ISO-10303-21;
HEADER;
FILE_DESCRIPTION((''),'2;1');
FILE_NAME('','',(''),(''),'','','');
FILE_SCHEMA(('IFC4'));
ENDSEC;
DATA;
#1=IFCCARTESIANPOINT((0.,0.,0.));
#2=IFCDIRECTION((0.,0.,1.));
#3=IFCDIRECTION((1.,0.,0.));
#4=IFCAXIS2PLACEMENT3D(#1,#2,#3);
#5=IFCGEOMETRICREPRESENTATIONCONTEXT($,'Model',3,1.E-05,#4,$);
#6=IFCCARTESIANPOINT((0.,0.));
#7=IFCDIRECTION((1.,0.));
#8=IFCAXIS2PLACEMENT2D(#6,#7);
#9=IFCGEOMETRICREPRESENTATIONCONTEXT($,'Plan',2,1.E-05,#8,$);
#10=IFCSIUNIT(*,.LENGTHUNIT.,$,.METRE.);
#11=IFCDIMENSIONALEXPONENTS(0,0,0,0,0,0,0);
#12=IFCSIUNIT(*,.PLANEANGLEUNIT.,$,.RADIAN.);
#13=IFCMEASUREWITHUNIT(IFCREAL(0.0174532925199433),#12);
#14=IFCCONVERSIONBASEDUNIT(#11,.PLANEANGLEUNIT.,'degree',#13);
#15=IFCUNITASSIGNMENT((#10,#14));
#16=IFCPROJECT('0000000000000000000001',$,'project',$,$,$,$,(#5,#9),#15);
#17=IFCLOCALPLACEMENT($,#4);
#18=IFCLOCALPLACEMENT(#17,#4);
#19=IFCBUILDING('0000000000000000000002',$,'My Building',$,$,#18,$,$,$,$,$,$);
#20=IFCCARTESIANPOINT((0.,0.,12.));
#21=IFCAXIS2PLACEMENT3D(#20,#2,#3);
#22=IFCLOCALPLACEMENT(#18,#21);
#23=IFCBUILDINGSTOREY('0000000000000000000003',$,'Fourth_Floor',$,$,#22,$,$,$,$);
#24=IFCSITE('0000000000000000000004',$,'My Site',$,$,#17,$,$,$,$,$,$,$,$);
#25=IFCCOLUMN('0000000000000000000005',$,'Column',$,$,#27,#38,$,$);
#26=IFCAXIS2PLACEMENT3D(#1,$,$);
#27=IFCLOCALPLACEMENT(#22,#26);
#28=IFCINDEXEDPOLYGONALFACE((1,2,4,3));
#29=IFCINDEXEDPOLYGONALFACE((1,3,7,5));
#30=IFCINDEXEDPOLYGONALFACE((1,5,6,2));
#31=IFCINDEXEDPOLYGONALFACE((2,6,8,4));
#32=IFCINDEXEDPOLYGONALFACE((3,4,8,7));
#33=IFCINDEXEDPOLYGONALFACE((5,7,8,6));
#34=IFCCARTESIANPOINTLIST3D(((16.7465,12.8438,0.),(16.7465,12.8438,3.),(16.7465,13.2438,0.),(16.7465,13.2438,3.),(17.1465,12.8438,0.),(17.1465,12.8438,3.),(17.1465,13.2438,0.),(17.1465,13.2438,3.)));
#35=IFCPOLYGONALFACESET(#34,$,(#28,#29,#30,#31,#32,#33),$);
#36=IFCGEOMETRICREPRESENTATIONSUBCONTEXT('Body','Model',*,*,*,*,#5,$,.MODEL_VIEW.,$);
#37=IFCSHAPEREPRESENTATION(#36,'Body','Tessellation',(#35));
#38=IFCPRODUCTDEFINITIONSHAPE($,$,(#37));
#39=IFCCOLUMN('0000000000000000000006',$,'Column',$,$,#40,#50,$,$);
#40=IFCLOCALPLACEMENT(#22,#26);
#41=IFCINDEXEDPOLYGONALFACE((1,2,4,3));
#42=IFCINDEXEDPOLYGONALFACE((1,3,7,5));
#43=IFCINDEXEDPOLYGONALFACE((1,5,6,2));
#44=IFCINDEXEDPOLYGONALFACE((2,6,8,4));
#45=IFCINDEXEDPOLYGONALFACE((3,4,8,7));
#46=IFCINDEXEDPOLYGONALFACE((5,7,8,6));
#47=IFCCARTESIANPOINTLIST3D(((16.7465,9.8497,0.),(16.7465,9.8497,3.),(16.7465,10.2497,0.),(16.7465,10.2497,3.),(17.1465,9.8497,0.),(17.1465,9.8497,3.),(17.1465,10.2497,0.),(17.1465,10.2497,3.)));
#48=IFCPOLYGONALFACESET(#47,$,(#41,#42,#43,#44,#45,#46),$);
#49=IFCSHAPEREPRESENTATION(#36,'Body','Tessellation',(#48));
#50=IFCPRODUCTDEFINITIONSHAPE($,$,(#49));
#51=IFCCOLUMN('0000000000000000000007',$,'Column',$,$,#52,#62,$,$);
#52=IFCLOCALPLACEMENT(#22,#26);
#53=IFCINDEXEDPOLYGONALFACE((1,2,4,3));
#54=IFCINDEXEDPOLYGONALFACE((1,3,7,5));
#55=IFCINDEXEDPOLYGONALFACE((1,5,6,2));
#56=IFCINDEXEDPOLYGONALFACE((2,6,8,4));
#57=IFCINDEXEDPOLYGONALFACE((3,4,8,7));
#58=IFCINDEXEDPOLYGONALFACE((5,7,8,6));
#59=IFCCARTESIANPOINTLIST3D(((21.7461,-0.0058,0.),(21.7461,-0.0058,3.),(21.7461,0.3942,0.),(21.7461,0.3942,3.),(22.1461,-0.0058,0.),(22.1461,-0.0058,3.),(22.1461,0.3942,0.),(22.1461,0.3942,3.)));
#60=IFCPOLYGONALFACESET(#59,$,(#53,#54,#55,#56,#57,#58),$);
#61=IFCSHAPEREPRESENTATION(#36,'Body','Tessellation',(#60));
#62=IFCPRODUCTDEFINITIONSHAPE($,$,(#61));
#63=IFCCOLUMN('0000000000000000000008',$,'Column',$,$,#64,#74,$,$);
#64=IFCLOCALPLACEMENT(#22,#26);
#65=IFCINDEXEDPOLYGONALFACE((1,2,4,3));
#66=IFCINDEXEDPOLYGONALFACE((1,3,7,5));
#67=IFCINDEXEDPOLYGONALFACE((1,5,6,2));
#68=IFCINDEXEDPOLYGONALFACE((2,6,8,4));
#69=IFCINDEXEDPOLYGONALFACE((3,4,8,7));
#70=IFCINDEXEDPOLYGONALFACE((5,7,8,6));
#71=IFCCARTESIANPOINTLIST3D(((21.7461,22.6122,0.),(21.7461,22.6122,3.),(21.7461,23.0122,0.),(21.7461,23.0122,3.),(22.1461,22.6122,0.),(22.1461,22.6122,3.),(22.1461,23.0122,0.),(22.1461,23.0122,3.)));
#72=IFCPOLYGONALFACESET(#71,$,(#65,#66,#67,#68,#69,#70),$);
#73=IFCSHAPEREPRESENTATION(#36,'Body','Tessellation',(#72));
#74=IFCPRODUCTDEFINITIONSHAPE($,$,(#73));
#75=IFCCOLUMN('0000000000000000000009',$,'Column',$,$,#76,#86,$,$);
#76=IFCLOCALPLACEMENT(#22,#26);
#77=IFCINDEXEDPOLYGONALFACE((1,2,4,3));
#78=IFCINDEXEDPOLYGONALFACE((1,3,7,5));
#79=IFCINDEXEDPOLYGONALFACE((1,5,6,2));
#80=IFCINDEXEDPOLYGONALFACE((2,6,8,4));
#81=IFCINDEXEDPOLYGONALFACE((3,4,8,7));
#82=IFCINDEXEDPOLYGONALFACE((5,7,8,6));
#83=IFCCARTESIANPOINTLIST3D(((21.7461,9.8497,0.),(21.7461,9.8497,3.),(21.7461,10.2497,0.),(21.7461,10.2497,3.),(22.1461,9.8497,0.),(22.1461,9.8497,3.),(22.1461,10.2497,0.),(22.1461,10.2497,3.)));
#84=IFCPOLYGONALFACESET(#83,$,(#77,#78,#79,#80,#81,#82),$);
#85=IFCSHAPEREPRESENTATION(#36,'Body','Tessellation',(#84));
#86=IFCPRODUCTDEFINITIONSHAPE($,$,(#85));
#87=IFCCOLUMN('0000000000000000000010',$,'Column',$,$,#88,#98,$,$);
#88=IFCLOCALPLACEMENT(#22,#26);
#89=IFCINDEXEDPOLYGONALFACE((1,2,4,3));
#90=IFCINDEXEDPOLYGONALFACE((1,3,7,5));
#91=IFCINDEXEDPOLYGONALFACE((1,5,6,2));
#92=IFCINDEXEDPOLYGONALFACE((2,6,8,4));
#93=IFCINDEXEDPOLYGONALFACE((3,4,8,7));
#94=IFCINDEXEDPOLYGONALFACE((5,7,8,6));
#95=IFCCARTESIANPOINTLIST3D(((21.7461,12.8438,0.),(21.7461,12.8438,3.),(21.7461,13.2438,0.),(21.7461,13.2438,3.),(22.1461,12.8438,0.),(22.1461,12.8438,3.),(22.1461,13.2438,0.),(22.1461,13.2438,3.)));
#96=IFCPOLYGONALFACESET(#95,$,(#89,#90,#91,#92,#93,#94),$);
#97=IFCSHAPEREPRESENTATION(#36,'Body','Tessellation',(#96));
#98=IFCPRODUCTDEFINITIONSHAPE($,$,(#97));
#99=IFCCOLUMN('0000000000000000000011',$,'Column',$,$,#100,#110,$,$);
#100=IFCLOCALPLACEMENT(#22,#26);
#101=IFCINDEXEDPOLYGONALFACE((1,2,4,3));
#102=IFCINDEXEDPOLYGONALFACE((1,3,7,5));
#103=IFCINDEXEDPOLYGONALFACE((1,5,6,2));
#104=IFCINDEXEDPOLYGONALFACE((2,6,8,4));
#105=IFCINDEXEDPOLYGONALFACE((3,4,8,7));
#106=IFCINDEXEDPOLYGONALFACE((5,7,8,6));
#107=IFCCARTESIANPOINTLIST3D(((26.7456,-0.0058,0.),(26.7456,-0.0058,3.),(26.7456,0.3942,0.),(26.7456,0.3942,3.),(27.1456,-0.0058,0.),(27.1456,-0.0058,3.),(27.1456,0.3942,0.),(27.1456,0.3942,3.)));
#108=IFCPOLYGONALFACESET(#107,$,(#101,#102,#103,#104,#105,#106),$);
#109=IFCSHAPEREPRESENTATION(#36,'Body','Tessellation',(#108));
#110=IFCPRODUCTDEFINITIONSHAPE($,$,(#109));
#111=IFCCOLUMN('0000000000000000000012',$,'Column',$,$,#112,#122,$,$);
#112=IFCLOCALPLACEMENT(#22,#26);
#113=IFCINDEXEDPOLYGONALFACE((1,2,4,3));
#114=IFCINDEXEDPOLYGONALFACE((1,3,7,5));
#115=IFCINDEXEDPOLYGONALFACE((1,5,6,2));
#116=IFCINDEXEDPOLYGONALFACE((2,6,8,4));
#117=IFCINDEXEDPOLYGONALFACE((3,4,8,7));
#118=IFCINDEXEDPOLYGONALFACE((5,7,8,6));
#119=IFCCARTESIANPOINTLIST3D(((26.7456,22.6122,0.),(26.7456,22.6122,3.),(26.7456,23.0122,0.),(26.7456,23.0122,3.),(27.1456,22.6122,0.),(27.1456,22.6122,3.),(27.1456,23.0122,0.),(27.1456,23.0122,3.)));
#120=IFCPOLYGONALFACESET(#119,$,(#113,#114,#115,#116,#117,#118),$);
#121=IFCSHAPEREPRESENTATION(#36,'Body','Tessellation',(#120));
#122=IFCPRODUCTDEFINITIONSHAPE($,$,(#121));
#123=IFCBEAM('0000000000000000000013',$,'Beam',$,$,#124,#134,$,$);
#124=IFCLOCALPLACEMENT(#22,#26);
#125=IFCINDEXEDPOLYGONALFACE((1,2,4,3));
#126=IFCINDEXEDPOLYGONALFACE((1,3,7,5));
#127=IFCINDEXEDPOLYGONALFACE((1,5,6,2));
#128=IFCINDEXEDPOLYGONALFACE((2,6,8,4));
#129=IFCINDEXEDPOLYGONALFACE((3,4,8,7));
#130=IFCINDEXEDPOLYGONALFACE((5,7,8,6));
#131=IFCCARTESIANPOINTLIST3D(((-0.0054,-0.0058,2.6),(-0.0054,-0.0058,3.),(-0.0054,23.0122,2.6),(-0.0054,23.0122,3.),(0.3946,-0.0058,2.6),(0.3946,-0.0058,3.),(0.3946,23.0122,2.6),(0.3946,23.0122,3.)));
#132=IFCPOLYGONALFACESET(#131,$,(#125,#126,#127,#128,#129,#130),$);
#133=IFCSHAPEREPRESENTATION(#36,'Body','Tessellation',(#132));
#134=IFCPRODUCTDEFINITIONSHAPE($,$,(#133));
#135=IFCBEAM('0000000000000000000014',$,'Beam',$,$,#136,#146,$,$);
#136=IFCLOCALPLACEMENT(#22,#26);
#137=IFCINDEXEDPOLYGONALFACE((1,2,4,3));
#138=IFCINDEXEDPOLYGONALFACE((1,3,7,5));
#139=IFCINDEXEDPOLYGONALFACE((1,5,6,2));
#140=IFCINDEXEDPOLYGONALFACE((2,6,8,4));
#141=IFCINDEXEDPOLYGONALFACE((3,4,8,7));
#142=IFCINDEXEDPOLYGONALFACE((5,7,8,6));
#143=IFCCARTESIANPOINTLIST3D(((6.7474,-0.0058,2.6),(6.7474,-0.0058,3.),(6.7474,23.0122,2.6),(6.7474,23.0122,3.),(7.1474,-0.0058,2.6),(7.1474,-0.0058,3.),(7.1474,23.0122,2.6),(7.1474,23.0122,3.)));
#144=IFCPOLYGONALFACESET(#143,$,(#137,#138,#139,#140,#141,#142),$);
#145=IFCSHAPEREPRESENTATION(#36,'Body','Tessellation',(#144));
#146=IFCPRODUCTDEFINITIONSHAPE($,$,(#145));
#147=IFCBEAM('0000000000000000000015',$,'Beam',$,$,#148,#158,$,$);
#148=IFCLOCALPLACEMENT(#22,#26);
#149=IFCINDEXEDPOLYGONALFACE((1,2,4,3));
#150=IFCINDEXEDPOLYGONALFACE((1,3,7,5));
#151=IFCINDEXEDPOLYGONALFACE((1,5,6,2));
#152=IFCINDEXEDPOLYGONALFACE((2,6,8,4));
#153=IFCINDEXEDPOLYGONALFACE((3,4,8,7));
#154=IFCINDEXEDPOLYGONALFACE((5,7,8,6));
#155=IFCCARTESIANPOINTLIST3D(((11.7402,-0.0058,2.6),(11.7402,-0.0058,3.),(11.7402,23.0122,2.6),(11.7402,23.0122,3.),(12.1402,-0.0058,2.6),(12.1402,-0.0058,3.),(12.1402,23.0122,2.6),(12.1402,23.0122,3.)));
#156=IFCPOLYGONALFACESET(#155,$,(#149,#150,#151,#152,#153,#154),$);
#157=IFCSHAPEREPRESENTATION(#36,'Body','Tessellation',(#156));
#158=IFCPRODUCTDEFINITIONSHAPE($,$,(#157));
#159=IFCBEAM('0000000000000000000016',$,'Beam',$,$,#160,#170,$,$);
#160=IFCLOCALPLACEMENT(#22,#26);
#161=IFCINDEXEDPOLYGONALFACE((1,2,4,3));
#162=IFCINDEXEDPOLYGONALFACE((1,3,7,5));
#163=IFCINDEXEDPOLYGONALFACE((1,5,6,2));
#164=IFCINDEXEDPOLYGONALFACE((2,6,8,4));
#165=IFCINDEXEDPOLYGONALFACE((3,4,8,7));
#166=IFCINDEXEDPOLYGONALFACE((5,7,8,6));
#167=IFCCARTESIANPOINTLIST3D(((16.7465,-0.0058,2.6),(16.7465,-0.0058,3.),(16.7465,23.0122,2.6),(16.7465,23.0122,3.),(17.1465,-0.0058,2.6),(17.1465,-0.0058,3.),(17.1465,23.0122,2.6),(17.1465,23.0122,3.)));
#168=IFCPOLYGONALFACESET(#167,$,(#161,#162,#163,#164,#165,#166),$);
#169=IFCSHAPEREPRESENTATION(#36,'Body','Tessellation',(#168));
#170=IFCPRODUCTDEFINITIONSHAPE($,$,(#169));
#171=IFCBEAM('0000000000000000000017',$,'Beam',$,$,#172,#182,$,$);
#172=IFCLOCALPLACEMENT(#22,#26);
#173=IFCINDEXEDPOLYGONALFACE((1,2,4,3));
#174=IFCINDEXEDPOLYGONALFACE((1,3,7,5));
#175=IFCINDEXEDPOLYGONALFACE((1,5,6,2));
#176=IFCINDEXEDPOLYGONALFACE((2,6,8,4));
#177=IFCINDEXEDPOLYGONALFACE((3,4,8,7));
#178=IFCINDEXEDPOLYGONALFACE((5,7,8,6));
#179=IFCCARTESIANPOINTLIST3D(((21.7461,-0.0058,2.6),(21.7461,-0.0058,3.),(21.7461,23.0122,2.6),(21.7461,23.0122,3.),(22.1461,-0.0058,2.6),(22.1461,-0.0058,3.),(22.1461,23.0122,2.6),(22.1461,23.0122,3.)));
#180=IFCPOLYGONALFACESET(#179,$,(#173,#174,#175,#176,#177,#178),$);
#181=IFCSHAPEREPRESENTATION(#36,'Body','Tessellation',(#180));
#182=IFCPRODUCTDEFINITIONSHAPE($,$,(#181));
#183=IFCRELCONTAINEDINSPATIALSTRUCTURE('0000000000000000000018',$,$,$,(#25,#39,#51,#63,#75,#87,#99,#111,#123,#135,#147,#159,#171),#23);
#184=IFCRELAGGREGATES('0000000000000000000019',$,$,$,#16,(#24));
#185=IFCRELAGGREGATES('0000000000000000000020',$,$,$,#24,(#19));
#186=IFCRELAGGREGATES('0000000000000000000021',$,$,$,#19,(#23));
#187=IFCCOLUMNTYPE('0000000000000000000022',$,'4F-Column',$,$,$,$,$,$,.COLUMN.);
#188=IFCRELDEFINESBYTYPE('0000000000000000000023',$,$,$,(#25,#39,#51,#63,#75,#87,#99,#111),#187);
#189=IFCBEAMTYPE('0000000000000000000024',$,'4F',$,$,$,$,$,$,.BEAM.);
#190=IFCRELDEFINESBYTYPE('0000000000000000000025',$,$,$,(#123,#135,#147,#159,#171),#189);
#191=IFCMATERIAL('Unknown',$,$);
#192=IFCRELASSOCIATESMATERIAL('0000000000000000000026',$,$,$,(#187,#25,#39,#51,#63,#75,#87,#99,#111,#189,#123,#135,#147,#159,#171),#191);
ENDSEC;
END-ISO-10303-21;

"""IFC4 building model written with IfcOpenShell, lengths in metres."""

from ifc_helpers import new_model, entity, si_unit, converted_unit, frame, origin_with_axes, origin_2d_with_axis, place, context, subcontext, project, spatial, rectangle, extrude, material, material_profile, profile_set, profile_usage, type_object, element, save


model = new_model("IFC4")

# Units and contexts
model_context = context("Model", 3, precision=1e-05, world=origin_with_axes())
plan_context = context("Plan", 2, precision=1e-05, world=origin_2d_with_axis())
body_context = subcontext(model_context, "Body", "Model", "MODEL_VIEW")
ifc_project = project(units=[si_unit("LENGTHUNIT", "METRE"), converted_unit("PLANEANGLEUNIT", "degree", entity("IfcReal", 0.0174532925199433), si_unit("PLANEANGLEUNIT", "RADIAN"), dimensions=[0, 0, 0, 0, 0, 0, 0])], contexts=[model_context, plan_context])

# Site, building, storey
site_placement = place(None, origin_with_axes())
site = spatial("IfcSite", under=ifc_project, at=site_placement, Name="My Site")
building_placement = place(site_placement, origin_with_axes())
building = spatial("IfcBuilding", under=site, at=building_placement, Name="My Building")
storey_placement = place(building_placement, frame((0.0, 0.0, 12.0), z_axis=(0.0, 0.0, 1.0), x_axis=(1.0, 0.0, 0.0)))
storey = spatial("IfcBuildingStorey", under=building, at=storey_placement, Name="Fourth_Floor")

# Columns
ifc_material = material(Name="Unknown")
ifc_material_profile_1 = material_profile(ifc_material, rectangle(XDim=0.4, YDim=0.4))
ifc_profile_set_1 = profile_set([ifc_material_profile_1])
column_type = type_object("IfcColumnType", Name="4F-Column", PredefinedType="COLUMN", material=ifc_profile_set_1)
ifc_profile_usage_1 = profile_usage(ifc_profile_set_1, cardinal=8)
column_1_placement = place(storey_placement, frame((16.9465, 13.2438, 0.0), z_axis=(0.0, 0.0, 1.0), x_axis=(1.0, 0.0, 0.0)))
element("IfcColumn", 1, at=column_1_placement, inside=storey, type_object=column_type, material=ifc_profile_usage_1, Name="Column", context=body_context, shape_type="SweptSolid", body=[
    extrude(rectangle(XDim=0.4, YDim=0.4), frame((0.0, -0.2, 0.0), z_axis=(0.0, 0.0, 1.0), x_axis=(1.0, 0.0, 0.0)), (0.0, 0.0, 1.0), 3.0),
])
ifc_profile_usage_2 = profile_usage(ifc_profile_set_1, cardinal=8)
column_2_placement = place(storey_placement, frame((16.9465, 10.2497, 0.0), z_axis=(0.0, 0.0, 1.0), x_axis=(1.0, 0.0, 0.0)))
element("IfcColumn", 2, at=column_2_placement, inside=storey, type_object=column_type, material=ifc_profile_usage_2, Name="Column", context=body_context, shape_type="SweptSolid", body=[
    extrude(rectangle(XDim=0.4, YDim=0.4), frame((0.0, -0.2, 0.0), z_axis=(0.0, 0.0, 1.0), x_axis=(1.0, 0.0, 0.0)), (0.0, 0.0, 1.0), 3.0),
])
ifc_profile_usage_3 = profile_usage(ifc_profile_set_1, cardinal=8)
column_3_placement = place(storey_placement, frame((21.9461, 0.3942, 0.0), z_axis=(0.0, 0.0, 1.0), x_axis=(1.0, 0.0, 0.0)))
element("IfcColumn", 3, at=column_3_placement, inside=storey, type_object=column_type, material=ifc_profile_usage_3, Name="Column", context=body_context, shape_type="SweptSolid", body=[
    extrude(rectangle(XDim=0.4, YDim=0.4), frame((0.0, -0.2, 0.0), z_axis=(0.0, 0.0, 1.0), x_axis=(1.0, 0.0, 0.0)), (0.0, 0.0, 1.0), 3.0),
])
ifc_profile_usage_4 = profile_usage(ifc_profile_set_1, cardinal=8)
column_4_placement = place(storey_placement, frame((21.9461, 23.0122, 0.0), z_axis=(0.0, 0.0, 1.0), x_axis=(1.0, 0.0, 0.0)))
element("IfcColumn", 4, at=column_4_placement, inside=storey, type_object=column_type, material=ifc_profile_usage_4, Name="Column", context=body_context, shape_type="SweptSolid", body=[
    extrude(rectangle(XDim=0.4, YDim=0.4), frame((0.0, -0.2, 0.0), z_axis=(0.0, 0.0, 1.0), x_axis=(1.0, 0.0, 0.0)), (0.0, 0.0, 1.0), 3.0),
])
ifc_profile_usage_5 = profile_usage(ifc_profile_set_1, cardinal=8)
column_5_placement = place(storey_placement, frame((21.9461, 10.2497, 0.0), z_axis=(0.0, 0.0, 1.0), x_axis=(1.0, 0.0, 0.0)))
element("IfcColumn", 5, at=column_5_placement, inside=storey, type_object=column_type, material=ifc_profile_usage_5, Name="Column", context=body_context, shape_type="SweptSolid", body=[
    extrude(rectangle(XDim=0.4, YDim=0.4), frame((0.0, -0.2, 0.0), z_axis=(0.0, 0.0, 1.0), x_axis=(1.0, 0.0, 0.0)), (0.0, 0.0, 1.0), 3.0),
])
ifc_profile_usage_6 = profile_usage(ifc_profile_set_1, cardinal=8)
column_6_placement = place(storey_placement, frame((21.9461, 13.2438, 0.0), z_axis=(0.0, 0.0, 1.0), x_axis=(1.0, 0.0, 0.0)))
element("IfcColumn", 6, at=column_6_placement, inside=storey, type_object=column_type, material=ifc_profile_usage_6, Name="Column", context=body_context, shape_type="SweptSolid", body=[
    extrude(rectangle(XDim=0.4, YDim=0.4), frame((0.0, -0.2, 0.0), z_axis=(0.0, 0.0, 1.0), x_axis=(1.0, 0.0, 0.0)), (0.0, 0.0, 1.0), 3.0),
])
ifc_profile_usage_7 = profile_usage(ifc_profile_set_1, cardinal=8)
column_7_placement = place(storey_placement, frame((26.9456, 0.3942, 0.0), z_axis=(0.0, 0.0, 1.0), x_axis=(1.0, 0.0, 0.0)))
element("IfcColumn", 7, at=column_7_placement, inside=storey, type_object=column_type, material=ifc_profile_usage_7, Name="Column", context=body_context, shape_type="SweptSolid", body=[
    extrude(rectangle(XDim=0.4, YDim=0.4), frame((0.0, -0.2, 0.0), z_axis=(0.0, 0.0, 1.0), x_axis=(1.0, 0.0, 0.0)), (0.0, 0.0, 1.0), 3.0),
])
ifc_profile_usage_8 = profile_usage(ifc_profile_set_1, cardinal=8)
column_8_placement = place(storey_placement, frame((26.9456, 23.0122, 0.0), z_axis=(0.0, 0.0, 1.0), x_axis=(1.0, 0.0, 0.0)))
element("IfcColumn", 8, at=column_8_placement, inside=storey, type_object=column_type, material=ifc_profile_usage_8, Name="Column", context=body_context, shape_type="SweptSolid", body=[
    extrude(rectangle(XDim=0.4, YDim=0.4), frame((0.0, -0.2, 0.0), z_axis=(0.0, 0.0, 1.0), x_axis=(1.0, 0.0, 0.0)), (0.0, 0.0, 1.0), 3.0),
])

# Beams
ifc_material_profile_2 = material_profile(ifc_material, rectangle(XDim=0.4, YDim=0.4))
ifc_profile_set_2 = profile_set([ifc_material_profile_2])
ifc_profile_usage_9 = profile_usage(ifc_profile_set_2, cardinal=8)
beam_type = type_object("IfcBeamType", Name="4F", PredefinedType="BEAM", material=ifc_profile_set_2)
beam_1_placement = place(storey_placement, frame((0.1946, -0.0058, 3.0), z_axis=(0.0, 1.0, 0.0), x_axis=(-1.0, 0.0, 0.0)))
element("IfcBeam", 9, at=beam_1_placement, inside=storey, type_object=beam_type, material=ifc_profile_usage_9, Name="Beam", context=body_context, shape_type="SweptSolid", body=[
    extrude(rectangle(XDim=0.4, YDim=0.4), frame((0.0, -0.2, 0.0), z_axis=(0.0, 0.0, 1.0), x_axis=(1.0, 0.0, 0.0)), (0.0, 0.0, 1.0), 23.018),
])
ifc_profile_usage_10 = profile_usage(ifc_profile_set_2, cardinal=8)
beam_2_placement = place(storey_placement, frame((6.9474, -0.0058, 3.0), z_axis=(0.0, 1.0, 0.0), x_axis=(-1.0, 0.0, 0.0)))
element("IfcBeam", 10, at=beam_2_placement, inside=storey, type_object=beam_type, material=ifc_profile_usage_10, Name="Beam", context=body_context, shape_type="SweptSolid", body=[
    extrude(rectangle(XDim=0.4, YDim=0.4), frame((0.0, -0.2, 0.0), z_axis=(0.0, 0.0, 1.0), x_axis=(1.0, 0.0, 0.0)), (0.0, 0.0, 1.0), 23.018),
])
ifc_profile_usage_11 = profile_usage(ifc_profile_set_2, cardinal=8)
beam_3_placement = place(storey_placement, frame((11.9402, -0.0058, 3.0), z_axis=(0.0, 1.0, 0.0), x_axis=(-1.0, 0.0, 0.0)))
element("IfcBeam", 11, at=beam_3_placement, inside=storey, type_object=beam_type, material=ifc_profile_usage_11, Name="Beam", context=body_context, shape_type="SweptSolid", body=[
    extrude(rectangle(XDim=0.4, YDim=0.4), frame((0.0, -0.2, 0.0), z_axis=(0.0, 0.0, 1.0), x_axis=(1.0, 0.0, 0.0)), (0.0, 0.0, 1.0), 23.018),
])
ifc_profile_usage_12 = profile_usage(ifc_profile_set_2, cardinal=8)
beam_4_placement = place(storey_placement, frame((16.9465, -0.0058, 3.0), z_axis=(0.0, 1.0, 0.0), x_axis=(-1.0, 0.0, 0.0)))
element("IfcBeam", 12, at=beam_4_placement, inside=storey, type_object=beam_type, material=ifc_profile_usage_12, Name="Beam", context=body_context, shape_type="SweptSolid", body=[
    extrude(rectangle(XDim=0.4, YDim=0.4), frame((0.0, -0.2, 0.0), z_axis=(0.0, 0.0, 1.0), x_axis=(1.0, 0.0, 0.0)), (0.0, 0.0, 1.0), 23.018),
])
ifc_profile_usage_13 = profile_usage(ifc_profile_set_2, cardinal=8)
beam_5_placement = place(storey_placement, frame((21.9461, -0.0058, 3.0), z_axis=(0.0, 1.0, 0.0), x_axis=(-1.0, 0.0, 0.0)))
element("IfcBeam", 13, at=beam_5_placement, inside=storey, type_object=beam_type, material=ifc_profile_usage_13, Name="Beam", context=body_context, shape_type="SweptSolid", body=[
    extrude(rectangle(XDim=0.4, YDim=0.4), frame((0.0, -0.2, 0.0), z_axis=(0.0, 0.0, 1.0), x_axis=(1.0, 0.0, 0.0)), (0.0, 0.0, 1.0), 23.018),
])

save(model, "model.ifc")
